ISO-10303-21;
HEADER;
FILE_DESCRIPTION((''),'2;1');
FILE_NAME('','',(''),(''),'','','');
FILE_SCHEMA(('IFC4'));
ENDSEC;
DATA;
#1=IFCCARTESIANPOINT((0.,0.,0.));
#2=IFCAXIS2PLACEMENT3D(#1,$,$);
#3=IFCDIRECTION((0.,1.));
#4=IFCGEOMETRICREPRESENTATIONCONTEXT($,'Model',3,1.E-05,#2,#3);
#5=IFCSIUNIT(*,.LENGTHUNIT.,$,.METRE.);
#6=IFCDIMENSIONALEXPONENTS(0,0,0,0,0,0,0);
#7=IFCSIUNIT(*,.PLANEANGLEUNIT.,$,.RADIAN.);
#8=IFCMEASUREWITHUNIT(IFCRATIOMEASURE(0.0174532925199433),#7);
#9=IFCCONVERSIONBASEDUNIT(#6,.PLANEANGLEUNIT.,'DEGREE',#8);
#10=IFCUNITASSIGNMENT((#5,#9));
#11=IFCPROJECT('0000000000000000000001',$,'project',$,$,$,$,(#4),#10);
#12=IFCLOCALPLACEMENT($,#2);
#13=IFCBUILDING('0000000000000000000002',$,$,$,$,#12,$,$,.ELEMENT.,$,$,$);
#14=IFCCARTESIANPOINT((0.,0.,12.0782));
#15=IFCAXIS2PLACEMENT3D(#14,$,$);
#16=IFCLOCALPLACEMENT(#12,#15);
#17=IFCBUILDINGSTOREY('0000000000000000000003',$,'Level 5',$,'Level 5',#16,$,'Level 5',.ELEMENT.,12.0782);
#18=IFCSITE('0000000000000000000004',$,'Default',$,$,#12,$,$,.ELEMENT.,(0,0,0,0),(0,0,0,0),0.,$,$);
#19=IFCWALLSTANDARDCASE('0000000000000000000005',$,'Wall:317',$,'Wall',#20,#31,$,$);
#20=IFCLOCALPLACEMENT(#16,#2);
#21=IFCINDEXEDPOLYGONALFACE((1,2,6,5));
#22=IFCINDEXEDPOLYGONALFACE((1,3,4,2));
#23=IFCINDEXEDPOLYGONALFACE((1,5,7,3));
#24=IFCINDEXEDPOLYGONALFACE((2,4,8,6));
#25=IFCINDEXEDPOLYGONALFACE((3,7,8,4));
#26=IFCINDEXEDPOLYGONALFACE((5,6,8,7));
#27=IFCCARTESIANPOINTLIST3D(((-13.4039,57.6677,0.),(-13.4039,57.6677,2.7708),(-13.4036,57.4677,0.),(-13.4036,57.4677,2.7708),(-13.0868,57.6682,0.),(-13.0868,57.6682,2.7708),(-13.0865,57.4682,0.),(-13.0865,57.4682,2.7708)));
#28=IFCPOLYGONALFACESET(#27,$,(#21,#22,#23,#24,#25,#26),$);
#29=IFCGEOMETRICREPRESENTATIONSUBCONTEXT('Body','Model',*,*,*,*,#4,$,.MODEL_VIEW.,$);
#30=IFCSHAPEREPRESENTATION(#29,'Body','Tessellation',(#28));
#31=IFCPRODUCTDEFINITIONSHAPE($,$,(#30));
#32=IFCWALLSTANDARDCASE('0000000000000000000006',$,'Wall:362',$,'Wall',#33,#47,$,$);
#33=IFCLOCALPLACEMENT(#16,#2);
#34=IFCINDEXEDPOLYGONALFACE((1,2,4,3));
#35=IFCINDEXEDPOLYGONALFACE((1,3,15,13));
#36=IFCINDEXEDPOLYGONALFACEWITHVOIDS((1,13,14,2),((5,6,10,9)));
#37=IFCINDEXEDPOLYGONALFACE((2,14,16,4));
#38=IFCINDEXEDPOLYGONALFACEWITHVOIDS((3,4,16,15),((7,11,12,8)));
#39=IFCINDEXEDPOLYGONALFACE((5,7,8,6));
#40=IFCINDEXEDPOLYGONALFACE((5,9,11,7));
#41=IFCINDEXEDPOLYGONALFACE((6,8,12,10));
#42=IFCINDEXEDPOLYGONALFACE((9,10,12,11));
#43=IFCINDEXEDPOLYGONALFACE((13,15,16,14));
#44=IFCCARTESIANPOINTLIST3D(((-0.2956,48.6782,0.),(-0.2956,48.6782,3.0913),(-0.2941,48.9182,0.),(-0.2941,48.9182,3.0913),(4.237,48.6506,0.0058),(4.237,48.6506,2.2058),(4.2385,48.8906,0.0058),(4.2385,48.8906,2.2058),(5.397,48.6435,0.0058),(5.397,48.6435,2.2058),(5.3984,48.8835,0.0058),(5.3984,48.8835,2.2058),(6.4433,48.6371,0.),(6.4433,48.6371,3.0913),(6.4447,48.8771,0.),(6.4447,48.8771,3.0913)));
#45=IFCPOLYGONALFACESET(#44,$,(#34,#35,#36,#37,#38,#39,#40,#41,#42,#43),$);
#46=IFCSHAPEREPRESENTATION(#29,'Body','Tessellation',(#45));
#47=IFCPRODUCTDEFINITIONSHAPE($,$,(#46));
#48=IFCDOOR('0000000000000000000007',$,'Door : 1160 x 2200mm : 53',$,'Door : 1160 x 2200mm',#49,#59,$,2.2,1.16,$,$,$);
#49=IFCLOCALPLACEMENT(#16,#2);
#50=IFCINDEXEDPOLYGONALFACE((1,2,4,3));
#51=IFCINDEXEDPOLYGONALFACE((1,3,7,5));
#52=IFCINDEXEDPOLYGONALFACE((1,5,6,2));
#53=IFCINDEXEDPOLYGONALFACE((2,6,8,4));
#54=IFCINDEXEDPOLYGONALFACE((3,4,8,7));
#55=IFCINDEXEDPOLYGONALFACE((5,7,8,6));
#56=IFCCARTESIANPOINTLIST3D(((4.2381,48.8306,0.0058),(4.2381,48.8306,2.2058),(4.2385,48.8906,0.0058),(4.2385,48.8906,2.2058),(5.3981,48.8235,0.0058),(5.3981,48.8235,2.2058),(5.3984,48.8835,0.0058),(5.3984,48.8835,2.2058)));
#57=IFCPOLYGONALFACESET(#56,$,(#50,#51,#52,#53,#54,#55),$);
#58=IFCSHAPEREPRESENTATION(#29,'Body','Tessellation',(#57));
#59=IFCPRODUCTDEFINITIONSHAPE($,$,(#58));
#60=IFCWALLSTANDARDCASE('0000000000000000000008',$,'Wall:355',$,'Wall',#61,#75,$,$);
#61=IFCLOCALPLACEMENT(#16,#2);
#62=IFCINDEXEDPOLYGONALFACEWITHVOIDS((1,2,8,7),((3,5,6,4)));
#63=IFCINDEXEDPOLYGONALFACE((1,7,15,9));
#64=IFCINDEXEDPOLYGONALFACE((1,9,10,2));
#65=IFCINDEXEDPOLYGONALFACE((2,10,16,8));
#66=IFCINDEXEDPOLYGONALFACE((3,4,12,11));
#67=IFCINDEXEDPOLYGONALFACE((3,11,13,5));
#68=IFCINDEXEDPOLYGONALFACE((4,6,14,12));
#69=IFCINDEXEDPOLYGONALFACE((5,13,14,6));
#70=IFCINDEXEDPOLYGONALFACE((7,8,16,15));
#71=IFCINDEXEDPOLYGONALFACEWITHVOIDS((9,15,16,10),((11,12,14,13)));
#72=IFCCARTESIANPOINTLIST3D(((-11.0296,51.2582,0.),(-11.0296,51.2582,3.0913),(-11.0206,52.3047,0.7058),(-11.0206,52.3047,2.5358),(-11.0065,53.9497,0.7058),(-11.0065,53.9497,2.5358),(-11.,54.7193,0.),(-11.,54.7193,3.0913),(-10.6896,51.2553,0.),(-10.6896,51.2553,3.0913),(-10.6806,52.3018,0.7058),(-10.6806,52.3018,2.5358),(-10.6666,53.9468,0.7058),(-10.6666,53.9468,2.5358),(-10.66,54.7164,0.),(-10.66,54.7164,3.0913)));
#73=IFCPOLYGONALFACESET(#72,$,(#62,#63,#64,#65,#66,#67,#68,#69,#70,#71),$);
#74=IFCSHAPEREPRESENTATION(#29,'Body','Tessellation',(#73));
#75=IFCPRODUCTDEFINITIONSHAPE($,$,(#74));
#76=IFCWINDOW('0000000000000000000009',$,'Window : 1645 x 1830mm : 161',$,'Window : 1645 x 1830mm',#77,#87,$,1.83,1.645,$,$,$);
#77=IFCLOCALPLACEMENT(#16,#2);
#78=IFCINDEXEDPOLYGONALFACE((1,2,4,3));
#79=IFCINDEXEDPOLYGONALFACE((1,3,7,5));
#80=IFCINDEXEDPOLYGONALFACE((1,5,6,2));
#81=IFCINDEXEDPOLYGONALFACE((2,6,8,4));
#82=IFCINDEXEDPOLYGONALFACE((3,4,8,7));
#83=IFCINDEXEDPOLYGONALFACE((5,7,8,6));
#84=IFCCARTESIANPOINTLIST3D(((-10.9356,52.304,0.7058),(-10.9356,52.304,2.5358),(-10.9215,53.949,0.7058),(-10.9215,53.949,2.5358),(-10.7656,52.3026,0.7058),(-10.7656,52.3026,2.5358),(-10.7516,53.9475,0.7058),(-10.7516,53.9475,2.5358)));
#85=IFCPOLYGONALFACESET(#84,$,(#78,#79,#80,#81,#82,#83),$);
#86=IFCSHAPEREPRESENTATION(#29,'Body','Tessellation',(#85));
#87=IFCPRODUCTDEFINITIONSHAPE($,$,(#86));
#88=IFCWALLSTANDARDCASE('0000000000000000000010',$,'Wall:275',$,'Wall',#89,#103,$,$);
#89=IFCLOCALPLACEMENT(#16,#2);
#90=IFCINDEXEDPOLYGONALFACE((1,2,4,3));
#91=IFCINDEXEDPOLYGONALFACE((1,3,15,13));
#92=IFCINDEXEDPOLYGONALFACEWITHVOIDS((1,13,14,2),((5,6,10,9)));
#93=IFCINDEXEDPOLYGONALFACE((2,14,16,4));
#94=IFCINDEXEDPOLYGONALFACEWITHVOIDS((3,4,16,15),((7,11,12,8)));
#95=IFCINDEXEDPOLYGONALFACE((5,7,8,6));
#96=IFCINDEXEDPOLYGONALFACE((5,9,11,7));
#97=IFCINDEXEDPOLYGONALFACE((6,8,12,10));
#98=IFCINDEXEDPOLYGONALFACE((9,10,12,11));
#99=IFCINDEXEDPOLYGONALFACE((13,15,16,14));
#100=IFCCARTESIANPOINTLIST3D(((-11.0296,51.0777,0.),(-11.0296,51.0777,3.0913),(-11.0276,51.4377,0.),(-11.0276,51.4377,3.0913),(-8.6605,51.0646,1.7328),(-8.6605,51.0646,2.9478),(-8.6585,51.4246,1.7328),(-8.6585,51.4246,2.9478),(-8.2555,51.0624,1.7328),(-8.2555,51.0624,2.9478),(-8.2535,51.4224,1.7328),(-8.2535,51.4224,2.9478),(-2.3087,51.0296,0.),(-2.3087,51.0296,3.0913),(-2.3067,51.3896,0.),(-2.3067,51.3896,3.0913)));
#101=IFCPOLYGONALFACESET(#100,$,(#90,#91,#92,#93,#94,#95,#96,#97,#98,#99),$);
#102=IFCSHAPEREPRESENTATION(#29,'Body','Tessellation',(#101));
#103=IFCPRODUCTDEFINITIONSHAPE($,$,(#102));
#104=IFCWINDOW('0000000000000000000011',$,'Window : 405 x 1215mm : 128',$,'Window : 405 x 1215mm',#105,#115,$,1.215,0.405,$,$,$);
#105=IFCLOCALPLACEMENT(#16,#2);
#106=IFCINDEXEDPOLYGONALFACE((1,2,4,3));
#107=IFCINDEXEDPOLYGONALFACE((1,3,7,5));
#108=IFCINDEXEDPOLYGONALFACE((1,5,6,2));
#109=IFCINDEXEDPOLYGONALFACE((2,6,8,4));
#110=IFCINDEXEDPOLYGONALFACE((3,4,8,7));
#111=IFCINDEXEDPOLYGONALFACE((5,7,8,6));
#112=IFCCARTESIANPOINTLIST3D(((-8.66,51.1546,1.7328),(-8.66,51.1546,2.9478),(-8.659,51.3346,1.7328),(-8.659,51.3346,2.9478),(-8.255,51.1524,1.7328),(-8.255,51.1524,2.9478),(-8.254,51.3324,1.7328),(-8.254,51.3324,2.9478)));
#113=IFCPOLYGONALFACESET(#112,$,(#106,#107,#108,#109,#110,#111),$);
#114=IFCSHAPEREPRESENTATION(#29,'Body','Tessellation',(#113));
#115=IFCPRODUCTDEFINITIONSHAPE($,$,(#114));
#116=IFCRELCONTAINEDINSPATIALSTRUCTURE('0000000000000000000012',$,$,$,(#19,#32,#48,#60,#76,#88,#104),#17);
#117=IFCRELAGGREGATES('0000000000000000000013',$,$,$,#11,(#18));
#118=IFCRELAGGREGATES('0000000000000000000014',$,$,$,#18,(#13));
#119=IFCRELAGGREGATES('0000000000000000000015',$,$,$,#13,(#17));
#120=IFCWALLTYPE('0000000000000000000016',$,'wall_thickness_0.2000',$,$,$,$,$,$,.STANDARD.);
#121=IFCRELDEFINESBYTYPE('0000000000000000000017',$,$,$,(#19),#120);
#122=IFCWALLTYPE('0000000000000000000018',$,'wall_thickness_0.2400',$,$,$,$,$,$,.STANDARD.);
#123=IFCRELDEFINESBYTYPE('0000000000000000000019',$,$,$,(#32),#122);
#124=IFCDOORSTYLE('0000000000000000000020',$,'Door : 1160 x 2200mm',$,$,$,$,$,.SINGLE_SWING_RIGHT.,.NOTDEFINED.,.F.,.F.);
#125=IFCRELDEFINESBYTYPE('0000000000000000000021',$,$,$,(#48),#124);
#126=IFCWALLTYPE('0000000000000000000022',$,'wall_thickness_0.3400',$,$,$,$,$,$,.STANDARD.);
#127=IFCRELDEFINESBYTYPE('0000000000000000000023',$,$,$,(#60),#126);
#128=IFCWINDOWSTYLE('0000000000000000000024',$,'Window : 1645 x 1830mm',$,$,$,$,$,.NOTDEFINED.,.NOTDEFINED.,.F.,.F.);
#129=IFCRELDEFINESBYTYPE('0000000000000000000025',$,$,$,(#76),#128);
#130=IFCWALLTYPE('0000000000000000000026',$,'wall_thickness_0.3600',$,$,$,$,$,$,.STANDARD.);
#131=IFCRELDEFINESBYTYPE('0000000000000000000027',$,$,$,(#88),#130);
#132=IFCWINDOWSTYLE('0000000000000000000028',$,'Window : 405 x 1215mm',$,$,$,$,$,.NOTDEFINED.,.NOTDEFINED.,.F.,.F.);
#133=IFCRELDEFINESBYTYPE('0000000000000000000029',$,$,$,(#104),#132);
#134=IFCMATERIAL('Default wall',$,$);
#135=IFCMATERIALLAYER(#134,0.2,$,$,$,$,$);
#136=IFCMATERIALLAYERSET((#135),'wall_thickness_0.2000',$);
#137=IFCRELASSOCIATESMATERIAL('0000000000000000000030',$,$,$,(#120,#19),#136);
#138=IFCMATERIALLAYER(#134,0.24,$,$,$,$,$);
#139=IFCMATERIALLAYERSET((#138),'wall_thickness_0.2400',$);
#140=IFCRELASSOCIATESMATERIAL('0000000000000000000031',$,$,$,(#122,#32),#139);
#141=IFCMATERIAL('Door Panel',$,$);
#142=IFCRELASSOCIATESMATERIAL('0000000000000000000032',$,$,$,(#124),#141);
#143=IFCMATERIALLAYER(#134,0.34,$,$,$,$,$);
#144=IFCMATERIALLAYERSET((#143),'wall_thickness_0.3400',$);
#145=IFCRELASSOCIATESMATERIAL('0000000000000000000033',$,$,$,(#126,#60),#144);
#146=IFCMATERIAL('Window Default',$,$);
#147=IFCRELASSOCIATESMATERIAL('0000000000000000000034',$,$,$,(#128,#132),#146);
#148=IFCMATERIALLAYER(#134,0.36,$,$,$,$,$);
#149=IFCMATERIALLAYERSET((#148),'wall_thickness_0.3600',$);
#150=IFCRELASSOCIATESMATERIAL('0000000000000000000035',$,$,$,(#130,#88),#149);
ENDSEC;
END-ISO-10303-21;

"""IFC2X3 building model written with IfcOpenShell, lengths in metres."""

from ifc_helpers import new_model, entity, si_unit, converted_unit, direction, frame, frame_2d, origin, origin_2d_with_axis, place, context, subcontext, project, spatial, polyline, rectangle, outline, extrude, clip, halfspace, source, transform, mapped, material, layer, layer_set, layer_usage, type_object, type_shapes, element, fill, save


model = new_model("IFC2X3")

# Units and contexts
model_context = context("Model", 3, precision=1e-05, world=origin(), true_north=direction((0.0, 1.0)))
body_context = subcontext(model_context, "Body", "Model", "MODEL_VIEW")
ifc_project = project(units=[si_unit("LENGTHUNIT", "METRE"), converted_unit("PLANEANGLEUNIT", "DEGREE", entity("IfcRatioMeasure", 0.0174532925199433), si_unit("PLANEANGLEUNIT", "RADIAN"), dimensions=[0, 0, 0, 0, 0, 0, 0])], contexts=[model_context])

# Site, building, storey
placement = place(None, origin())
site = spatial("IfcSite", under=ifc_project, at=placement, Name="Default", CompositionType="ELEMENT", RefLatitude=(0, 0, 0, 0), RefLongitude=(0, 0, 0, 0), RefElevation=0.0)
building = spatial("IfcBuilding", under=site, at=placement, CompositionType="ELEMENT")
storey_placement = place(placement, frame((0.0, 0.0, 12.0782)))
storey = spatial("IfcBuildingStorey", under=building, at=storey_placement, Name="Level 5", ObjectType="Level 5", LongName="Level 5", CompositionType="ELEMENT", Elevation=12.0782)

# Wall
ifc_material_1 = material(Name="Default wall")
ifc_layer_1 = layer(ifc_material_1, 0.2)
ifc_layer_set_1 = layer_set([ifc_layer_1], Name="wall_thickness_0.2000")
ifc_layer_usage_1 = layer_usage(ifc_layer_set_1, "AXIS2", "POSITIVE", -0.1)
wall_type_1 = type_object("IfcWallType", Name="wall_thickness_0.2000", PredefinedType="STANDARD", material=ifc_layer_set_1)
wall_1_placement = place(storey_placement, frame((-13.4037, 57.5677, 0.0), z_axis=(0.0, 0.0, 1.0), x_axis=(0.999999, 0.001443, 0.0)))
element("IfcWallStandardCase", 1, at=wall_1_placement, inside=storey, type_object=wall_type_1, material=ifc_layer_usage_1, Name="Wall:317", ObjectType="Wall", context=body_context, shape_type="SweptSolid", body=[
    extrude(outline(polyline([(0.3171, -0.1), (0.3171, 0.1), (0.0, 0.1), (0.0, -0.1), (0.3171, -0.1)])), origin(), (0.0, 0.0, 1.0), 2.7708),
])
ifc_layer_2 = layer(ifc_material_1, 0.24)
ifc_layer_set_2 = layer_set([ifc_layer_2], Name="wall_thickness_0.2400")
ifc_layer_usage_2 = layer_usage(ifc_layer_set_2, "AXIS2", "POSITIVE", -0.12)
wall_type_2 = type_object("IfcWallType", Name="wall_thickness_0.2400", PredefinedType="STANDARD", material=ifc_layer_set_2)

# Wall, opening, door
wall_2_placement = place(storey_placement, frame((-0.2949, 48.7982, 0.0), z_axis=(0.0, 0.0, 1.0), x_axis=(0.999981, -0.006099, 0.0)))
wall_2 = element("IfcWallStandardCase", 2, at=wall_2_placement, inside=storey, type_object=wall_type_2, material=ifc_layer_usage_2, Name="Wall:362", ObjectType="Wall", context=body_context, shape_type="Clipping", body=[
    clip(extrude(outline(polyline([(6.739, -0.12), (6.739, 0.12), (0.0, 0.12), (0.0, -0.12), (6.739, -0.12)])), origin(), (0.0, 0.0, 1.0), 3.0913), halfspace(frame((-1.1329, 27.0392, 5.7957), z_axis=(-0.3899, -0.000964, 0.920857), x_axis=(0.920856, 0.00007, 0.389903)), False)),
])
opening_1_placement = place(wall_2_placement, frame((4.5327, -0.12, 0.0058)))
opening_1 = element("IfcOpeningElement", 3, at=opening_1_placement, cuts=wall_2, ObjectType="Opening", context=body_context, shape_type="SweptSolid", body=[
    extrude(rectangle(XDim=1.16, YDim=2.2, at=frame_2d((1.1, 0.58), x_axis=(0.0, 1.0))), frame((0.0, 0.0, 0.0), z_axis=(0.0, 1.0, 0.0), x_axis=(0.0, 0.0, 1.0)), (0.0, 0.0, 1.0), 0.24),
])
ifc_material_2 = material(Name="Door Panel")
door_style_1 = type_object("IfcDoorStyle", Name="Door : 1160 x 2200mm", ConstructionType="NOTDEFINED", OperationType="SINGLE_SWING_RIGHT", ParameterTakesPrecedence=False, Sizeable=False, material=ifc_material_2)
shared_shape_1 = source(origin(), body_context, "Body", "SweptSolid", [
    extrude(rectangle(XDim=0.06, YDim=1.16, at=origin_2d_with_axis()), frame((0.58, 0.21, 0.0), z_axis=(0.0, 0.0, 1.0), x_axis=(0.0, 1.0, 0.0)), (0.0, 0.0, 1.0), 2.2),
])
type_shapes(door_style_1, [shared_shape_1])
door_1_placement = place(opening_1_placement, origin())
door_1 = element("IfcDoor", 4, at=door_1_placement, inside=storey, type_object=door_style_1, Name="Door : 1160 x 2200mm : 53", ObjectType="Door : 1160 x 2200mm", OverallHeight=2.2, OverallWidth=1.16, context=body_context, shape_type="MappedRepresentation", body=[
    mapped(shared_shape_1, transform((0.0, 0.0, 0.0), scale=1.0)),
])
fill(opening_1, door_1)

# Walls, openings, windows
ifc_layer_3 = layer(ifc_material_1, 0.34)
ifc_layer_set_3 = layer_set([ifc_layer_3], Name="wall_thickness_0.3400")
ifc_layer_usage_3 = layer_usage(ifc_layer_set_3, "AXIS2", "POSITIVE", -0.17)
wall_type_3 = type_object("IfcWallType", Name="wall_thickness_0.3400", PredefinedType="STANDARD", material=ifc_layer_set_3)
wall_3_placement = place(storey_placement, frame((-10.83, 54.7179, 0.0), z_axis=(0.0, 0.0, 1.0), x_axis=(-0.00855, -0.999963, 0.0)))
wall_3 = element("IfcWallStandardCase", 5, at=wall_3_placement, inside=storey, type_object=wall_type_3, material=ifc_layer_usage_3, Name="Wall:355", ObjectType="Wall", context=body_context, shape_type="Clipping", body=[
    clip(extrude(outline(polyline([(3.4613, -0.17), (3.4613, 0.17), (0.0, 0.17), (0.0, -0.17), (3.4613, -0.17)])), origin(), (0.0, 0.0, 1.0), 3.0913), halfspace(frame((-3.0728, -1.9495, 9.0175), z_axis=(0.391129, -0.000544, 0.920336), x_axis=(-0.0004, 1.0, 0.000761)), False)),
])
opening_2_placement = place(wall_3_placement, frame((0.7697, -0.17, 0.7058)))
opening_2 = element("IfcOpeningElement", 6, at=opening_2_placement, cuts=wall_3, ObjectType="Opening", context=body_context, shape_type="SweptSolid", body=[
    extrude(rectangle(XDim=1.645, YDim=1.83, at=frame_2d((0.915, 0.8225), x_axis=(0.0, 1.0))), frame((0.0, 0.0, 0.0), z_axis=(0.0, 1.0, 0.0), x_axis=(0.0, 0.0, 1.0)), (0.0, 0.0, 1.0), 0.34),
])
ifc_material_3 = material(Name="Window Default")
window_style_1 = type_object("IfcWindowStyle", Name="Window : 1645 x 1830mm", ConstructionType="NOTDEFINED", OperationType="NOTDEFINED", ParameterTakesPrecedence=False, Sizeable=False, material=ifc_material_3)
shared_shape_2 = source(origin(), body_context, "Body", "SweptSolid", [
    extrude(rectangle(XDim=0.17, YDim=1.645, at=origin_2d_with_axis()), frame((0.8225, 0.17, 0.0), z_axis=(0.0, 0.0, 1.0), x_axis=(0.0, 1.0, 0.0)), (0.0, 0.0, 1.0), 1.83),
])
type_shapes(window_style_1, [shared_shape_2])
window_1_placement = place(opening_2_placement, origin())
window_1 = element("IfcWindow", 7, at=window_1_placement, inside=storey, type_object=window_style_1, Name="Window : 1645 x 1830mm : 161", ObjectType="Window : 1645 x 1830mm", OverallHeight=1.83, OverallWidth=1.645, context=body_context, shape_type="MappedRepresentation", body=[
    mapped(shared_shape_2, transform((0.0, 0.0, 0.0), scale=1.0)),
])
fill(opening_2, window_1)
ifc_layer_4 = layer(ifc_material_1, 0.36)
ifc_layer_set_4 = layer_set([ifc_layer_4], Name="wall_thickness_0.3600")
ifc_layer_usage_4 = layer_usage(ifc_layer_set_4, "AXIS2", "POSITIVE", -0.18)
wall_type_4 = type_object("IfcWallType", Name="wall_thickness_0.3600", PredefinedType="STANDARD", material=ifc_layer_set_4)
wall_4_placement = place(storey_placement, frame((-11.0286, 51.2577, 0.0), z_axis=(0.0, 0.0, 1.0), x_axis=(0.999985, -0.005512, 0.0)))
wall_4 = element("IfcWallStandardCase", 8, at=wall_4_placement, inside=storey, type_object=wall_type_4, material=ifc_layer_usage_4, Name="Wall:275", ObjectType="Wall", context=body_context, shape_type="Clipping", body=[
    clip(extrude(outline(polyline([(8.721, -0.18), (8.721, 0.18), (0.0, 0.18), (0.0, -0.18), (8.721, -0.18)])), origin(), (0.0, 0.0, 1.0), 3.0913), halfspace(frame((-1.7607, 6.54, 9.0175), z_axis=(-0.001732, -0.391126, 0.920336), x_axis=(0.999996, -0.002638, 0.000761)), False)),
])
opening_3_placement = place(wall_4_placement, frame((2.3692, -0.18, 1.7328)))
opening_3 = element("IfcOpeningElement", 9, at=opening_3_placement, cuts=wall_4, ObjectType="Opening", context=body_context, shape_type="SweptSolid", body=[
    extrude(rectangle(XDim=0.405, YDim=1.215, at=frame_2d((0.6075, 0.2025), x_axis=(0.0, 1.0))), frame((0.0, 0.0, 0.0), z_axis=(0.0, 1.0, 0.0), x_axis=(0.0, 0.0, 1.0)), (0.0, 0.0, 1.0), 0.36),
])
window_style_2 = type_object("IfcWindowStyle", Name="Window : 405 x 1215mm", ConstructionType="NOTDEFINED", OperationType="NOTDEFINED", ParameterTakesPrecedence=False, Sizeable=False, material=ifc_material_3)
shared_shape_3 = source(origin(), body_context, "Body", "SweptSolid", [
    extrude(rectangle(XDim=0.18, YDim=0.405, at=origin_2d_with_axis()), frame((0.2025, 0.18, 0.0), z_axis=(0.0, 0.0, 1.0), x_axis=(0.0, 1.0, 0.0)), (0.0, 0.0, 1.0), 1.215),
])
type_shapes(window_style_2, [shared_shape_3])
window_2_placement = place(opening_3_placement, origin())
window_2 = element("IfcWindow", 10, at=window_2_placement, inside=storey, type_object=window_style_2, Name="Window : 405 x 1215mm : 128", ObjectType="Window : 405 x 1215mm", OverallHeight=1.215, OverallWidth=0.405, context=body_context, shape_type="MappedRepresentation", body=[
    mapped(shared_shape_3, transform((0.0, 0.0, 0.0), scale=1.0)),
])
fill(opening_3, window_2)

save(model, "model.ifc")
